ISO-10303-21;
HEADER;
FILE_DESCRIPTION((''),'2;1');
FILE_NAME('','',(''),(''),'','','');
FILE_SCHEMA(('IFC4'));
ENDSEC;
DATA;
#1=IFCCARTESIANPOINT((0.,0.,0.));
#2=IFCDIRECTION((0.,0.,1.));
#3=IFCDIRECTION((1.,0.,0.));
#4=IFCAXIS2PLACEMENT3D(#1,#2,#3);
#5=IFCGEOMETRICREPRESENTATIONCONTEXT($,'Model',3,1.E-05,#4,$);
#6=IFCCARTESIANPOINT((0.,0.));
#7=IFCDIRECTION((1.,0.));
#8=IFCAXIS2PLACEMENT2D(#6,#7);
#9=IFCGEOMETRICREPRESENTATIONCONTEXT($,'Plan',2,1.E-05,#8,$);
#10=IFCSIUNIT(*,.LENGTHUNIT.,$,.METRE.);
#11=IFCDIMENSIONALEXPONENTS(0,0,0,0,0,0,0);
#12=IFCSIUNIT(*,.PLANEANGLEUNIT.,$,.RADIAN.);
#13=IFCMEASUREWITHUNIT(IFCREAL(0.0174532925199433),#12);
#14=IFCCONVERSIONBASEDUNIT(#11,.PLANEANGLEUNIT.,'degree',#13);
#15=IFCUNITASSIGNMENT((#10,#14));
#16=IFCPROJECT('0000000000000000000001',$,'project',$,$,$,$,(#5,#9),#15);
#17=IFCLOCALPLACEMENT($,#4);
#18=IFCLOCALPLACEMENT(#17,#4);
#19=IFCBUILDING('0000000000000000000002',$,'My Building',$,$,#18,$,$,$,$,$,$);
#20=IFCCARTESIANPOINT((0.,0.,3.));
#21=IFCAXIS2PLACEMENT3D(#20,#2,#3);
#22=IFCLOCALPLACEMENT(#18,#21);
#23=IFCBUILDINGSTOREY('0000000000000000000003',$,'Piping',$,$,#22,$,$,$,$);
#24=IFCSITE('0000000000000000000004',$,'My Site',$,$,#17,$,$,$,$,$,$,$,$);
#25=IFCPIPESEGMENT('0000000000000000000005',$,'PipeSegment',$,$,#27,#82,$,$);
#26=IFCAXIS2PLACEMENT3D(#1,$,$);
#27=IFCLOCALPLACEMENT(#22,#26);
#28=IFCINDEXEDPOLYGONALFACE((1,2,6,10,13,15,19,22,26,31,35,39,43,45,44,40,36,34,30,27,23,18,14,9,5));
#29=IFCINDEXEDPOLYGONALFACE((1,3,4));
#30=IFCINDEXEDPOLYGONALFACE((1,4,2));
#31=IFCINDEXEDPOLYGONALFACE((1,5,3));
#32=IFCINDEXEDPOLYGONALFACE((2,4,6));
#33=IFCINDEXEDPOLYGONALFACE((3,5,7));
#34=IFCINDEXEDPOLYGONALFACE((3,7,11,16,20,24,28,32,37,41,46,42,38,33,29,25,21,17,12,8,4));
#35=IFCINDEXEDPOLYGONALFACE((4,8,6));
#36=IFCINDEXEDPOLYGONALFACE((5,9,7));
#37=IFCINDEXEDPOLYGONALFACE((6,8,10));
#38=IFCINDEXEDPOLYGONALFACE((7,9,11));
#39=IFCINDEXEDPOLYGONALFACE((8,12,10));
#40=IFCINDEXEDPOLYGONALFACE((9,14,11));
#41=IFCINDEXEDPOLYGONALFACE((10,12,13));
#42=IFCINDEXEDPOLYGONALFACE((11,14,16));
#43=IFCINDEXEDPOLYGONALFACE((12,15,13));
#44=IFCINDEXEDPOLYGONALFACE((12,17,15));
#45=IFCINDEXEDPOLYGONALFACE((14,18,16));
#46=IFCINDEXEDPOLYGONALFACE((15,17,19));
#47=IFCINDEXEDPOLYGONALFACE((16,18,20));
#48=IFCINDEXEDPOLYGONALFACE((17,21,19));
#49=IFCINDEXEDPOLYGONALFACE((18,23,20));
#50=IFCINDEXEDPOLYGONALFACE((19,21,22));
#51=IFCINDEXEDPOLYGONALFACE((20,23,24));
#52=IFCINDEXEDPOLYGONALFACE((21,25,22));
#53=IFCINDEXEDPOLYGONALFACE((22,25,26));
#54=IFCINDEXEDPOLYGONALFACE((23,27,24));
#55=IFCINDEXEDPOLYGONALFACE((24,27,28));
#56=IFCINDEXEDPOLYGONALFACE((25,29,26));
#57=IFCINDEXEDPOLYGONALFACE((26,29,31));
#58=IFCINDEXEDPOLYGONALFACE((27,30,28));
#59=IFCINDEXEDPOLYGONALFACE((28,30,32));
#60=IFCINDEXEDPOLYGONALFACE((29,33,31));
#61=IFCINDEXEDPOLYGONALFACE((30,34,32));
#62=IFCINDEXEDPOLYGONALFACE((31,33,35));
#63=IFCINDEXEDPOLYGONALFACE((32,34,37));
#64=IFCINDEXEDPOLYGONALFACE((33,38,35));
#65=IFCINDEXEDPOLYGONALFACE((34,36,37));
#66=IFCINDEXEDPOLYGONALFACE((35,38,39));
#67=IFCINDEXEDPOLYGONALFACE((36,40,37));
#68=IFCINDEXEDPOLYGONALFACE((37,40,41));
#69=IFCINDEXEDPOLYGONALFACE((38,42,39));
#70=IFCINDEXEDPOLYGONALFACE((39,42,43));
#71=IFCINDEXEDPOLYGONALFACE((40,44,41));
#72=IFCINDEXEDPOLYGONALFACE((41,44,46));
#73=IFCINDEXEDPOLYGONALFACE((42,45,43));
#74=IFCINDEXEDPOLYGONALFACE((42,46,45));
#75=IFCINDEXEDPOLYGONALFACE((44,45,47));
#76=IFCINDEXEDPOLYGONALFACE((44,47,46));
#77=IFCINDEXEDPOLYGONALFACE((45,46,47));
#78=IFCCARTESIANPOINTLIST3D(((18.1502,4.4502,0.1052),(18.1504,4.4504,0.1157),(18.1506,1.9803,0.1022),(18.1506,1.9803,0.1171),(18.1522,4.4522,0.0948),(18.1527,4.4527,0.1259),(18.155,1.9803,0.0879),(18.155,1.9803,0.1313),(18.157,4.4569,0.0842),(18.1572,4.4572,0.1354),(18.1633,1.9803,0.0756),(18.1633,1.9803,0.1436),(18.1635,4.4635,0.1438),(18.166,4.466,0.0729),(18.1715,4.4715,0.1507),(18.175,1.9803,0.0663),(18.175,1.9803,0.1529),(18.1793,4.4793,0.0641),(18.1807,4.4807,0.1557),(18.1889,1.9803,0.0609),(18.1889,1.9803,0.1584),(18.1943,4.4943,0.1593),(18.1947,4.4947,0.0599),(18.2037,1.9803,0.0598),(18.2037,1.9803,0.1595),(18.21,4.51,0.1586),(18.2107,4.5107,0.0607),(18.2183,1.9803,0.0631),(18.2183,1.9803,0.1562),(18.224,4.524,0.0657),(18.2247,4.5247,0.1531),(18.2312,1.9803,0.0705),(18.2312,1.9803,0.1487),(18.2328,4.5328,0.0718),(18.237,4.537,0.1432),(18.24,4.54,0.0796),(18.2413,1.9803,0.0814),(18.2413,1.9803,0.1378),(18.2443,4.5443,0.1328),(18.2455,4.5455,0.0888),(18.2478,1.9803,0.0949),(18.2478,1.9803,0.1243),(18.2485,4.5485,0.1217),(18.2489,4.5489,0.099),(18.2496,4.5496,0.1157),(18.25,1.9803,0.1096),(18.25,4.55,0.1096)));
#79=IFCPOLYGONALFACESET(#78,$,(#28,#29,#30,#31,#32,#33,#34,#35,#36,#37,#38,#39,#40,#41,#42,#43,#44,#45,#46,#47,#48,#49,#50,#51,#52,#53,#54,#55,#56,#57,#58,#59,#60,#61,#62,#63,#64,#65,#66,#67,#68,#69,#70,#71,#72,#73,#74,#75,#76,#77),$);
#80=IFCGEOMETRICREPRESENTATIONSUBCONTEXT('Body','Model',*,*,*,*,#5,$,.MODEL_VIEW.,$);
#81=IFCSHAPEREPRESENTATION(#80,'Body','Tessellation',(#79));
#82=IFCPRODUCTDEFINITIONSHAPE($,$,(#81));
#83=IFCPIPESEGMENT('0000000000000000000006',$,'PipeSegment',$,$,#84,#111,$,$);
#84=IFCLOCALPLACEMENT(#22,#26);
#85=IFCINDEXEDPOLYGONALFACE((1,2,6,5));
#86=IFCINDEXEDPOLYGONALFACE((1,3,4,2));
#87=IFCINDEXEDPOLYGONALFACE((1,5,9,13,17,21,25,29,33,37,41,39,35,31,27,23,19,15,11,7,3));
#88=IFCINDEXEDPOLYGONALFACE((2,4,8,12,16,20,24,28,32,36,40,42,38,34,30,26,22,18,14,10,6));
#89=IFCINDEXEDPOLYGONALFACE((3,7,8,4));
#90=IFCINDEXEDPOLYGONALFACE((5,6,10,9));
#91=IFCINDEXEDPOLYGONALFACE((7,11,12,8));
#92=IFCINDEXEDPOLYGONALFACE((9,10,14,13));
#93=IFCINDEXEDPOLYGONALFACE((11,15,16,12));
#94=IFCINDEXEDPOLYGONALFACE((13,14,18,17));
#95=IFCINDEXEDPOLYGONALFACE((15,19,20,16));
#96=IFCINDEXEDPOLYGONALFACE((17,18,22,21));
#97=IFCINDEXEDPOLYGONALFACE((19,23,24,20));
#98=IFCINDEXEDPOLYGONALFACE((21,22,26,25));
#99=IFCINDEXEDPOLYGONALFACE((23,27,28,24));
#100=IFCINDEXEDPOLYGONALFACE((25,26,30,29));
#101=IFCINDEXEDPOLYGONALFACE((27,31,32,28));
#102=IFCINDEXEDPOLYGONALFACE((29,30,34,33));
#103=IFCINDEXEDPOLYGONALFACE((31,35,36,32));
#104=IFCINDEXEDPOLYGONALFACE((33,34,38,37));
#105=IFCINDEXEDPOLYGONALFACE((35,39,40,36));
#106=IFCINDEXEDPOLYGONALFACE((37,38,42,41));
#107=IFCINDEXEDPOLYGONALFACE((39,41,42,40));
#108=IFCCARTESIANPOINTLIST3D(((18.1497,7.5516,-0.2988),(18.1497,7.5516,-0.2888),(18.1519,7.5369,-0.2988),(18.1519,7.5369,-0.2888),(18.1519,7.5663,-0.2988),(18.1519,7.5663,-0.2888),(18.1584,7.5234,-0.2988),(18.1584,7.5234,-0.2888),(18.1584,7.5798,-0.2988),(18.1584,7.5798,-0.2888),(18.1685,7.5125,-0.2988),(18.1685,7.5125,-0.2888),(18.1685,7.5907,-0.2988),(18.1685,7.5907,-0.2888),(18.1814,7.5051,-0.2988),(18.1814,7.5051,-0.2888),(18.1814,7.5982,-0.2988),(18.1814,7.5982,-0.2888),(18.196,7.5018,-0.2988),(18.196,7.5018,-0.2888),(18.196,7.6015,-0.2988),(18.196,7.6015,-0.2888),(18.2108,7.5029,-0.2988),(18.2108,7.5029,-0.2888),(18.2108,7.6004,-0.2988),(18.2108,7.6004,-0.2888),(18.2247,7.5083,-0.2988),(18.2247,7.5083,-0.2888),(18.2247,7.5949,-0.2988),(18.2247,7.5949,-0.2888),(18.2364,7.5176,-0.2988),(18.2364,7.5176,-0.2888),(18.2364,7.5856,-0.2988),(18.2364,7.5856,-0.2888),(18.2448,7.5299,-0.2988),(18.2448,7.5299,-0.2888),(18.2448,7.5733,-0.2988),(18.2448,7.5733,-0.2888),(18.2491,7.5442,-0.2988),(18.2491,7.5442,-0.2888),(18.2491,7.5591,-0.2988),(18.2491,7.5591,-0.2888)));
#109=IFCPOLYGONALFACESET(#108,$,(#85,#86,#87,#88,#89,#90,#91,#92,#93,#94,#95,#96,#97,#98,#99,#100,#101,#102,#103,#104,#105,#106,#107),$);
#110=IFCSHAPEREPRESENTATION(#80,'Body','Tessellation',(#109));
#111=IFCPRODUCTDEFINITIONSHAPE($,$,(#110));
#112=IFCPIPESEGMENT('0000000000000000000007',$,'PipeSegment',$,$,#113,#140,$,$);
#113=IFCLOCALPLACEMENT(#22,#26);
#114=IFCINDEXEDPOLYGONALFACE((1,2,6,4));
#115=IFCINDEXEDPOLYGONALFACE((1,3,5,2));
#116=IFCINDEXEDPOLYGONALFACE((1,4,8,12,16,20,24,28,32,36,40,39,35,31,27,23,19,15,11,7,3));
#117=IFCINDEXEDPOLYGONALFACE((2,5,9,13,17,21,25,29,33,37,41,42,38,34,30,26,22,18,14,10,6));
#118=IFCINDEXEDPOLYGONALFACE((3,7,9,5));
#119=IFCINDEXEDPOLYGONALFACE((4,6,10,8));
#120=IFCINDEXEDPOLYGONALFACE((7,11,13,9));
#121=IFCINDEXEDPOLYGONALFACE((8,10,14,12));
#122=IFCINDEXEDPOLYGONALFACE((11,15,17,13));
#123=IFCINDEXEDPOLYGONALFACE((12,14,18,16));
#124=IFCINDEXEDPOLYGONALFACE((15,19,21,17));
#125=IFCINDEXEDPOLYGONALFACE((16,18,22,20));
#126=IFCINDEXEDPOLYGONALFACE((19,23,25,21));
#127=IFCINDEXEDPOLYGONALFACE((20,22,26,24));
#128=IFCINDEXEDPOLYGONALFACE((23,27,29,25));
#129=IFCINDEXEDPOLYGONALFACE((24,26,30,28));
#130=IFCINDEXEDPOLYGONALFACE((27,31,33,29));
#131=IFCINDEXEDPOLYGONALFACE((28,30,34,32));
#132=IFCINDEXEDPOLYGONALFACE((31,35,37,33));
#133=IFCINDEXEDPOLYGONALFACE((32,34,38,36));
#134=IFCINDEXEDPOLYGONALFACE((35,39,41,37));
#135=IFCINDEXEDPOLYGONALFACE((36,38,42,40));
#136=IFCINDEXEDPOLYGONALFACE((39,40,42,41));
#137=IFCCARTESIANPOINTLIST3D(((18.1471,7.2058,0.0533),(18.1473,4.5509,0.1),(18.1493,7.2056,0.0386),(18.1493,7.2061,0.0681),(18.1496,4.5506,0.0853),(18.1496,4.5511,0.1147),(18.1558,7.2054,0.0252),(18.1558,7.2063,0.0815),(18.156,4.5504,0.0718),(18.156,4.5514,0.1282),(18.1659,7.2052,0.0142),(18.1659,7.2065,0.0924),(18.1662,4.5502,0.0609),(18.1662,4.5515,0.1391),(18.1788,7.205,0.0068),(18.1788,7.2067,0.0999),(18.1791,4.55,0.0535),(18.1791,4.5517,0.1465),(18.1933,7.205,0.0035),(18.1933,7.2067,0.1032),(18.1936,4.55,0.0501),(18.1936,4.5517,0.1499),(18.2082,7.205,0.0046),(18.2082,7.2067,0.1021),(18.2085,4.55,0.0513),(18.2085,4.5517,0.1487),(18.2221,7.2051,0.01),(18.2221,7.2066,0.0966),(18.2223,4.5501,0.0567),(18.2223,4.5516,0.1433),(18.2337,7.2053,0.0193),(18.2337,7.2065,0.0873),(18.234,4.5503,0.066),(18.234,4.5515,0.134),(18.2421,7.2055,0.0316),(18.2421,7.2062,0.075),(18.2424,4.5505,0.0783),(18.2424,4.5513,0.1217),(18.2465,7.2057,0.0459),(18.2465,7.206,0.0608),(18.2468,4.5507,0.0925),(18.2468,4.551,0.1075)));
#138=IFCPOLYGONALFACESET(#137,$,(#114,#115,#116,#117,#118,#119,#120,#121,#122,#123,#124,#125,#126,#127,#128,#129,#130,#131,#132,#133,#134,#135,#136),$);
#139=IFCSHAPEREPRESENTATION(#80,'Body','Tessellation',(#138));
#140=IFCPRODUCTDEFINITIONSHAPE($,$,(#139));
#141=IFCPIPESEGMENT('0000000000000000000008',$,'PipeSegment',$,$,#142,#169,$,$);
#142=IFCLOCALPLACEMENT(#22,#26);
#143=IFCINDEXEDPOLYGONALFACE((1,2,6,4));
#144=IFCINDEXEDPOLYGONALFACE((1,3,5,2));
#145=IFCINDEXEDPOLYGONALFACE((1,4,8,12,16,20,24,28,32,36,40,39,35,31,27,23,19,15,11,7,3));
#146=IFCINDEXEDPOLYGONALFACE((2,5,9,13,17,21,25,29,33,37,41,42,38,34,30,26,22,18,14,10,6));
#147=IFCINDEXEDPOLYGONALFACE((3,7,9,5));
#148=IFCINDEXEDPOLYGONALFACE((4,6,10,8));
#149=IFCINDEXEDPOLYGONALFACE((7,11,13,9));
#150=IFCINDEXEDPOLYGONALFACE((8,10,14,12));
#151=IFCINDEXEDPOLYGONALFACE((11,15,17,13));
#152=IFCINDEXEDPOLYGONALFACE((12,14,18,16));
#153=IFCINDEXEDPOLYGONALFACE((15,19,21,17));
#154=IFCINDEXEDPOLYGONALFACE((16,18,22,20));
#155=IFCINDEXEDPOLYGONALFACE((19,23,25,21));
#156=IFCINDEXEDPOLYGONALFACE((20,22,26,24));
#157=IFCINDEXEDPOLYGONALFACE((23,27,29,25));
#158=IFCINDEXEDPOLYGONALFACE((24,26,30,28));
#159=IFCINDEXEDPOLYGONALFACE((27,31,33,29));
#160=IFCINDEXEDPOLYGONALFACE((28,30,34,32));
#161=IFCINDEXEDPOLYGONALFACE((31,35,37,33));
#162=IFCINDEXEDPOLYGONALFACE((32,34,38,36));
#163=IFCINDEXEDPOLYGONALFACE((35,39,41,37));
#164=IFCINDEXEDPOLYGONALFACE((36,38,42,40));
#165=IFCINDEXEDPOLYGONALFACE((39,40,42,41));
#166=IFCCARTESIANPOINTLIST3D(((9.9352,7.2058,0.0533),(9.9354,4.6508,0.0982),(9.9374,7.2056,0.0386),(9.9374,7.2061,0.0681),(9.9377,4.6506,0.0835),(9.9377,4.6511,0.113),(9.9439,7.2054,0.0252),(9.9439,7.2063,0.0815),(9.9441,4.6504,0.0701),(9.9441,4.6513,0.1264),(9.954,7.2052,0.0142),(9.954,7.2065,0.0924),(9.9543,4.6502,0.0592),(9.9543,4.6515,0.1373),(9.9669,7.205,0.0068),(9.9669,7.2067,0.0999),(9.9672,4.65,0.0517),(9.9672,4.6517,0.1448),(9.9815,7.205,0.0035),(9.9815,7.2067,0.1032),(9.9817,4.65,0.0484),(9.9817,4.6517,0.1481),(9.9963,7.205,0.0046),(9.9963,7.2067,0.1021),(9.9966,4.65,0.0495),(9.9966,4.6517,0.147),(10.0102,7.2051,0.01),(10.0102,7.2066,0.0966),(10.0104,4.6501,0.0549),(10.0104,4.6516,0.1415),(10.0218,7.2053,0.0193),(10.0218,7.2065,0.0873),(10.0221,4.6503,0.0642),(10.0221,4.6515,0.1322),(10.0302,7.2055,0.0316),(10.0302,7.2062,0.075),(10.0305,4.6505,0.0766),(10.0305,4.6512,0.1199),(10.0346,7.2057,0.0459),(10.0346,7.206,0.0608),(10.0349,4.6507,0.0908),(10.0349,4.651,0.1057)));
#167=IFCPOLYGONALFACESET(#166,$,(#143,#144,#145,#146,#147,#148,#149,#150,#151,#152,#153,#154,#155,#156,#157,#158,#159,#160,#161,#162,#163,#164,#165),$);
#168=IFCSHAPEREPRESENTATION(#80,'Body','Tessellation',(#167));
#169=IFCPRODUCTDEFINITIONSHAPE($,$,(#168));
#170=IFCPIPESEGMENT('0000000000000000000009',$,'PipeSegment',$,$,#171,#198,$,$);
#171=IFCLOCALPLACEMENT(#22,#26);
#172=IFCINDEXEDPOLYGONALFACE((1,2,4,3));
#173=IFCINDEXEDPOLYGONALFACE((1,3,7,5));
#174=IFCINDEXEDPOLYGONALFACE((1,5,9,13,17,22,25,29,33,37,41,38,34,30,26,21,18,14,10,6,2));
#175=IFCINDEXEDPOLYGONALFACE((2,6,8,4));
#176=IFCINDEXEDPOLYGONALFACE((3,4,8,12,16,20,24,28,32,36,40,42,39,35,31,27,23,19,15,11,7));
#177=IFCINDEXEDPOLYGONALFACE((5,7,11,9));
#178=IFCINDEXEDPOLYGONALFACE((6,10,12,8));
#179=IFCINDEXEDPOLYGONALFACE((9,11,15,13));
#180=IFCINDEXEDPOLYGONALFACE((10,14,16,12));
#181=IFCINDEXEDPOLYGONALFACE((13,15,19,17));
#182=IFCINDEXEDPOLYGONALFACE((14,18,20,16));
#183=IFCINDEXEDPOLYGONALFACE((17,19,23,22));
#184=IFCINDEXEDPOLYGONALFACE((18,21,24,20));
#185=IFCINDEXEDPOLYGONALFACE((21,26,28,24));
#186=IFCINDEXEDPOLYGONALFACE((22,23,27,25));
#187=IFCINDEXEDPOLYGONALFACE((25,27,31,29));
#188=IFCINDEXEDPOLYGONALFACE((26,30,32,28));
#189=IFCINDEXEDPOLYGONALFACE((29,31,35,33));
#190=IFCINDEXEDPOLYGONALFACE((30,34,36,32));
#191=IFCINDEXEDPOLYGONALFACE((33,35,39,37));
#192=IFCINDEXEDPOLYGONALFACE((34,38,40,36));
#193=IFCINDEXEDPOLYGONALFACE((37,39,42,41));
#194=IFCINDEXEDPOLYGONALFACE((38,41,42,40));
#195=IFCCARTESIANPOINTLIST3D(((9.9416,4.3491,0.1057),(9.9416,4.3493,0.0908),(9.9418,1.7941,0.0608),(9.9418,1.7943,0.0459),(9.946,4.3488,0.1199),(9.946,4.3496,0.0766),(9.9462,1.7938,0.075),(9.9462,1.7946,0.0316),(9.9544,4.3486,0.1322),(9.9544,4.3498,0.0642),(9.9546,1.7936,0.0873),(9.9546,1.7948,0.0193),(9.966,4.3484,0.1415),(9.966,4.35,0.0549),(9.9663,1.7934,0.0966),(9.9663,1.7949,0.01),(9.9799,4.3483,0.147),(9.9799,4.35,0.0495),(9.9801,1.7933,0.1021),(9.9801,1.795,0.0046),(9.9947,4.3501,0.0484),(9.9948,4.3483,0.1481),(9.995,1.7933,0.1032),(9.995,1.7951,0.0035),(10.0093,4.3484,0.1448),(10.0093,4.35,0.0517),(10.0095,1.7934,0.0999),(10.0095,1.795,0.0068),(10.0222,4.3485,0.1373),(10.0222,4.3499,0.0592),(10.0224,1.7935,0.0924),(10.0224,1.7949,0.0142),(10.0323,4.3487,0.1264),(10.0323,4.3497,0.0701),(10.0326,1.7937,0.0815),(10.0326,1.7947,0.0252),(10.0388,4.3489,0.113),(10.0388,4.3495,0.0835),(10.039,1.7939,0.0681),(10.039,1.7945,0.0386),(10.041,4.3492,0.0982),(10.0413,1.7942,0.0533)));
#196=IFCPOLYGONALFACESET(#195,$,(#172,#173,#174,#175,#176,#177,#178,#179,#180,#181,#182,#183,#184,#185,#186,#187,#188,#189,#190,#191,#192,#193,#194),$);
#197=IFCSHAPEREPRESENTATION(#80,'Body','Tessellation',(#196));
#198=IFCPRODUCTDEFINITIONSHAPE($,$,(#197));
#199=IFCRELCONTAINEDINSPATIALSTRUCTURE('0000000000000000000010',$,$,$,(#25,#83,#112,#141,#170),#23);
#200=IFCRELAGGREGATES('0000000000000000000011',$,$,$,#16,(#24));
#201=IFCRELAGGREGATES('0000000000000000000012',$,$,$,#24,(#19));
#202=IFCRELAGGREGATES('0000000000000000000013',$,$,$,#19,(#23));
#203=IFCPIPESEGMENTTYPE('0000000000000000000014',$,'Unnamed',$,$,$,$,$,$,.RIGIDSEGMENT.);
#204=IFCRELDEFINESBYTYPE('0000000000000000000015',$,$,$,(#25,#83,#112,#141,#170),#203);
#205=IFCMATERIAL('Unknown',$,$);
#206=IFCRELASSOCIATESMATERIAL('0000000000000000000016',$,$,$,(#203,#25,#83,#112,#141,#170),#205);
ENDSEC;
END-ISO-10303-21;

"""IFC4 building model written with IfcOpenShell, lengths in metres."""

from ifc_helpers import new_model, entity, si_unit, converted_unit, frame, origin_with_axes, origin_2d_with_axis, place, context, subcontext, project, spatial, circle, extrude, clip, halfspace, material, material_profile, profile_set, profile_usage, type_object, element, save


model = new_model("IFC4")

# Units and contexts
model_context = context("Model", 3, precision=1e-05, world=origin_with_axes())
plan_context = context("Plan", 2, precision=1e-05, world=origin_2d_with_axis())
body_context = subcontext(model_context, "Body", "Model", "MODEL_VIEW")
ifc_project = project(units=[si_unit("LENGTHUNIT", "METRE"), converted_unit("PLANEANGLEUNIT", "degree", entity("IfcReal", 0.0174532925199433), si_unit("PLANEANGLEUNIT", "RADIAN"), dimensions=[0, 0, 0, 0, 0, 0, 0])], contexts=[model_context, plan_context])

# Site, building, storey
site_placement = place(None, origin_with_axes())
site = spatial("IfcSite", under=ifc_project, at=site_placement, Name="My Site")
building_placement = place(site_placement, origin_with_axes())
building = spatial("IfcBuilding", under=site, at=building_placement, Name="My Building")
storey_placement = place(building_placement, frame((0.0, 0.0, 3.0), z_axis=(0.0, 0.0, 1.0), x_axis=(1.0, 0.0, 0.0)))
storey = spatial("IfcBuildingStorey", under=building, at=storey_placement, Name="Piping")

# Pipe segments
ifc_material = material(Name="Unknown")
ifc_material_profile_1 = material_profile(ifc_material, circle(Radius=0.05))
ifc_profile_set_1 = profile_set([ifc_material_profile_1])
pipe_segment_type = type_object("IfcPipeSegmentType", Name="Unnamed", PredefinedType="RIGIDSEGMENT", material=ifc_profile_set_1)
ifc_profile_usage_1 = profile_usage(ifc_profile_set_1, cardinal=5)
pipe_segment_1_placement = place(storey_placement, frame((18.2, 4.55, 0.1096), z_axis=(0.0, -1.0, 0.000006), x_axis=(1.0, 0.0, 0.0)))
element("IfcPipeSegment", 1, at=pipe_segment_1_placement, inside=storey, type_object=pipe_segment_type, material=ifc_profile_usage_1, Name="PipeSegment", context=body_context, shape_type="Clipping", body=[
    clip(extrude(circle(Radius=0.05), origin_with_axes(), (0.0, 0.0, 1.0), 2.5697), halfspace(frame((0.05, -3.1096, 0.0), z_axis=(-0.707114, 0.000005, -0.7071), x_axis=(0.000007, 1.0, 0.0)), False)),
])
ifc_profile_usage_2 = profile_usage(ifc_profile_set_1, cardinal=5)
pipe_segment_2_placement = place(storey_placement, frame((18.1997, 7.5516, -0.2888), z_axis=(0.0, 0.0, -1.0), x_axis=(-1.0, 0.0, 0.0)))
element("IfcPipeSegment", 2, at=pipe_segment_2_placement, inside=storey, type_object=pipe_segment_type, material=ifc_profile_usage_2, Name="PipeSegment", context=body_context, shape_type="SweptSolid", body=[
    extrude(circle(Radius=0.05), origin_with_axes(), (0.0, 0.0, 1.0), 0.01),
])
ifc_profile_usage_3 = profile_usage(ifc_profile_set_1, cardinal=5)
pipe_segment_3_placement = place(storey_placement, frame((18.1973, 4.5509, 0.1), z_axis=(-0.000099, 0.999846, -0.017575), x_axis=(-1.0, -0.000099, 0.0)))
element("IfcPipeSegment", 3, at=pipe_segment_3_placement, inside=storey, type_object=pipe_segment_type, material=ifc_profile_usage_3, Name="PipeSegment", context=body_context, shape_type="SweptSolid", body=[
    extrude(circle(Radius=0.05), origin_with_axes(), (0.0, 0.0, 1.0), 2.6554),
])
ifc_profile_usage_4 = profile_usage(ifc_profile_set_1, cardinal=5)
pipe_segment_4_placement = place(storey_placement, frame((9.9854, 4.6508, 0.0982), z_axis=(-0.000099, 0.999846, -0.017575), x_axis=(-1.0, -0.000099, 0.0)))
element("IfcPipeSegment", 4, at=pipe_segment_4_placement, inside=storey, type_object=pipe_segment_type, material=ifc_profile_usage_4, Name="PipeSegment", context=body_context, shape_type="SweptSolid", body=[
    extrude(circle(Radius=0.05), origin_with_axes(), (0.0, 0.0, 1.0), 2.5554),
])
ifc_profile_usage_5 = profile_usage(ifc_profile_set_1, cardinal=5)
pipe_segment_5_placement = place(storey_placement, frame((9.991, 4.3492, 0.0982), z_axis=(0.000099, -0.999846, -0.017575), x_axis=(1.0, 0.000099, -0.000001)))
element("IfcPipeSegment", 5, at=pipe_segment_5_placement, inside=storey, type_object=pipe_segment_type, material=ifc_profile_usage_5, Name="PipeSegment", context=body_context, shape_type="SweptSolid", body=[
    extrude(circle(Radius=0.05), origin_with_axes(), (0.0, 0.0, 1.0), 2.5554),
])

save(model, "model.ifc")
